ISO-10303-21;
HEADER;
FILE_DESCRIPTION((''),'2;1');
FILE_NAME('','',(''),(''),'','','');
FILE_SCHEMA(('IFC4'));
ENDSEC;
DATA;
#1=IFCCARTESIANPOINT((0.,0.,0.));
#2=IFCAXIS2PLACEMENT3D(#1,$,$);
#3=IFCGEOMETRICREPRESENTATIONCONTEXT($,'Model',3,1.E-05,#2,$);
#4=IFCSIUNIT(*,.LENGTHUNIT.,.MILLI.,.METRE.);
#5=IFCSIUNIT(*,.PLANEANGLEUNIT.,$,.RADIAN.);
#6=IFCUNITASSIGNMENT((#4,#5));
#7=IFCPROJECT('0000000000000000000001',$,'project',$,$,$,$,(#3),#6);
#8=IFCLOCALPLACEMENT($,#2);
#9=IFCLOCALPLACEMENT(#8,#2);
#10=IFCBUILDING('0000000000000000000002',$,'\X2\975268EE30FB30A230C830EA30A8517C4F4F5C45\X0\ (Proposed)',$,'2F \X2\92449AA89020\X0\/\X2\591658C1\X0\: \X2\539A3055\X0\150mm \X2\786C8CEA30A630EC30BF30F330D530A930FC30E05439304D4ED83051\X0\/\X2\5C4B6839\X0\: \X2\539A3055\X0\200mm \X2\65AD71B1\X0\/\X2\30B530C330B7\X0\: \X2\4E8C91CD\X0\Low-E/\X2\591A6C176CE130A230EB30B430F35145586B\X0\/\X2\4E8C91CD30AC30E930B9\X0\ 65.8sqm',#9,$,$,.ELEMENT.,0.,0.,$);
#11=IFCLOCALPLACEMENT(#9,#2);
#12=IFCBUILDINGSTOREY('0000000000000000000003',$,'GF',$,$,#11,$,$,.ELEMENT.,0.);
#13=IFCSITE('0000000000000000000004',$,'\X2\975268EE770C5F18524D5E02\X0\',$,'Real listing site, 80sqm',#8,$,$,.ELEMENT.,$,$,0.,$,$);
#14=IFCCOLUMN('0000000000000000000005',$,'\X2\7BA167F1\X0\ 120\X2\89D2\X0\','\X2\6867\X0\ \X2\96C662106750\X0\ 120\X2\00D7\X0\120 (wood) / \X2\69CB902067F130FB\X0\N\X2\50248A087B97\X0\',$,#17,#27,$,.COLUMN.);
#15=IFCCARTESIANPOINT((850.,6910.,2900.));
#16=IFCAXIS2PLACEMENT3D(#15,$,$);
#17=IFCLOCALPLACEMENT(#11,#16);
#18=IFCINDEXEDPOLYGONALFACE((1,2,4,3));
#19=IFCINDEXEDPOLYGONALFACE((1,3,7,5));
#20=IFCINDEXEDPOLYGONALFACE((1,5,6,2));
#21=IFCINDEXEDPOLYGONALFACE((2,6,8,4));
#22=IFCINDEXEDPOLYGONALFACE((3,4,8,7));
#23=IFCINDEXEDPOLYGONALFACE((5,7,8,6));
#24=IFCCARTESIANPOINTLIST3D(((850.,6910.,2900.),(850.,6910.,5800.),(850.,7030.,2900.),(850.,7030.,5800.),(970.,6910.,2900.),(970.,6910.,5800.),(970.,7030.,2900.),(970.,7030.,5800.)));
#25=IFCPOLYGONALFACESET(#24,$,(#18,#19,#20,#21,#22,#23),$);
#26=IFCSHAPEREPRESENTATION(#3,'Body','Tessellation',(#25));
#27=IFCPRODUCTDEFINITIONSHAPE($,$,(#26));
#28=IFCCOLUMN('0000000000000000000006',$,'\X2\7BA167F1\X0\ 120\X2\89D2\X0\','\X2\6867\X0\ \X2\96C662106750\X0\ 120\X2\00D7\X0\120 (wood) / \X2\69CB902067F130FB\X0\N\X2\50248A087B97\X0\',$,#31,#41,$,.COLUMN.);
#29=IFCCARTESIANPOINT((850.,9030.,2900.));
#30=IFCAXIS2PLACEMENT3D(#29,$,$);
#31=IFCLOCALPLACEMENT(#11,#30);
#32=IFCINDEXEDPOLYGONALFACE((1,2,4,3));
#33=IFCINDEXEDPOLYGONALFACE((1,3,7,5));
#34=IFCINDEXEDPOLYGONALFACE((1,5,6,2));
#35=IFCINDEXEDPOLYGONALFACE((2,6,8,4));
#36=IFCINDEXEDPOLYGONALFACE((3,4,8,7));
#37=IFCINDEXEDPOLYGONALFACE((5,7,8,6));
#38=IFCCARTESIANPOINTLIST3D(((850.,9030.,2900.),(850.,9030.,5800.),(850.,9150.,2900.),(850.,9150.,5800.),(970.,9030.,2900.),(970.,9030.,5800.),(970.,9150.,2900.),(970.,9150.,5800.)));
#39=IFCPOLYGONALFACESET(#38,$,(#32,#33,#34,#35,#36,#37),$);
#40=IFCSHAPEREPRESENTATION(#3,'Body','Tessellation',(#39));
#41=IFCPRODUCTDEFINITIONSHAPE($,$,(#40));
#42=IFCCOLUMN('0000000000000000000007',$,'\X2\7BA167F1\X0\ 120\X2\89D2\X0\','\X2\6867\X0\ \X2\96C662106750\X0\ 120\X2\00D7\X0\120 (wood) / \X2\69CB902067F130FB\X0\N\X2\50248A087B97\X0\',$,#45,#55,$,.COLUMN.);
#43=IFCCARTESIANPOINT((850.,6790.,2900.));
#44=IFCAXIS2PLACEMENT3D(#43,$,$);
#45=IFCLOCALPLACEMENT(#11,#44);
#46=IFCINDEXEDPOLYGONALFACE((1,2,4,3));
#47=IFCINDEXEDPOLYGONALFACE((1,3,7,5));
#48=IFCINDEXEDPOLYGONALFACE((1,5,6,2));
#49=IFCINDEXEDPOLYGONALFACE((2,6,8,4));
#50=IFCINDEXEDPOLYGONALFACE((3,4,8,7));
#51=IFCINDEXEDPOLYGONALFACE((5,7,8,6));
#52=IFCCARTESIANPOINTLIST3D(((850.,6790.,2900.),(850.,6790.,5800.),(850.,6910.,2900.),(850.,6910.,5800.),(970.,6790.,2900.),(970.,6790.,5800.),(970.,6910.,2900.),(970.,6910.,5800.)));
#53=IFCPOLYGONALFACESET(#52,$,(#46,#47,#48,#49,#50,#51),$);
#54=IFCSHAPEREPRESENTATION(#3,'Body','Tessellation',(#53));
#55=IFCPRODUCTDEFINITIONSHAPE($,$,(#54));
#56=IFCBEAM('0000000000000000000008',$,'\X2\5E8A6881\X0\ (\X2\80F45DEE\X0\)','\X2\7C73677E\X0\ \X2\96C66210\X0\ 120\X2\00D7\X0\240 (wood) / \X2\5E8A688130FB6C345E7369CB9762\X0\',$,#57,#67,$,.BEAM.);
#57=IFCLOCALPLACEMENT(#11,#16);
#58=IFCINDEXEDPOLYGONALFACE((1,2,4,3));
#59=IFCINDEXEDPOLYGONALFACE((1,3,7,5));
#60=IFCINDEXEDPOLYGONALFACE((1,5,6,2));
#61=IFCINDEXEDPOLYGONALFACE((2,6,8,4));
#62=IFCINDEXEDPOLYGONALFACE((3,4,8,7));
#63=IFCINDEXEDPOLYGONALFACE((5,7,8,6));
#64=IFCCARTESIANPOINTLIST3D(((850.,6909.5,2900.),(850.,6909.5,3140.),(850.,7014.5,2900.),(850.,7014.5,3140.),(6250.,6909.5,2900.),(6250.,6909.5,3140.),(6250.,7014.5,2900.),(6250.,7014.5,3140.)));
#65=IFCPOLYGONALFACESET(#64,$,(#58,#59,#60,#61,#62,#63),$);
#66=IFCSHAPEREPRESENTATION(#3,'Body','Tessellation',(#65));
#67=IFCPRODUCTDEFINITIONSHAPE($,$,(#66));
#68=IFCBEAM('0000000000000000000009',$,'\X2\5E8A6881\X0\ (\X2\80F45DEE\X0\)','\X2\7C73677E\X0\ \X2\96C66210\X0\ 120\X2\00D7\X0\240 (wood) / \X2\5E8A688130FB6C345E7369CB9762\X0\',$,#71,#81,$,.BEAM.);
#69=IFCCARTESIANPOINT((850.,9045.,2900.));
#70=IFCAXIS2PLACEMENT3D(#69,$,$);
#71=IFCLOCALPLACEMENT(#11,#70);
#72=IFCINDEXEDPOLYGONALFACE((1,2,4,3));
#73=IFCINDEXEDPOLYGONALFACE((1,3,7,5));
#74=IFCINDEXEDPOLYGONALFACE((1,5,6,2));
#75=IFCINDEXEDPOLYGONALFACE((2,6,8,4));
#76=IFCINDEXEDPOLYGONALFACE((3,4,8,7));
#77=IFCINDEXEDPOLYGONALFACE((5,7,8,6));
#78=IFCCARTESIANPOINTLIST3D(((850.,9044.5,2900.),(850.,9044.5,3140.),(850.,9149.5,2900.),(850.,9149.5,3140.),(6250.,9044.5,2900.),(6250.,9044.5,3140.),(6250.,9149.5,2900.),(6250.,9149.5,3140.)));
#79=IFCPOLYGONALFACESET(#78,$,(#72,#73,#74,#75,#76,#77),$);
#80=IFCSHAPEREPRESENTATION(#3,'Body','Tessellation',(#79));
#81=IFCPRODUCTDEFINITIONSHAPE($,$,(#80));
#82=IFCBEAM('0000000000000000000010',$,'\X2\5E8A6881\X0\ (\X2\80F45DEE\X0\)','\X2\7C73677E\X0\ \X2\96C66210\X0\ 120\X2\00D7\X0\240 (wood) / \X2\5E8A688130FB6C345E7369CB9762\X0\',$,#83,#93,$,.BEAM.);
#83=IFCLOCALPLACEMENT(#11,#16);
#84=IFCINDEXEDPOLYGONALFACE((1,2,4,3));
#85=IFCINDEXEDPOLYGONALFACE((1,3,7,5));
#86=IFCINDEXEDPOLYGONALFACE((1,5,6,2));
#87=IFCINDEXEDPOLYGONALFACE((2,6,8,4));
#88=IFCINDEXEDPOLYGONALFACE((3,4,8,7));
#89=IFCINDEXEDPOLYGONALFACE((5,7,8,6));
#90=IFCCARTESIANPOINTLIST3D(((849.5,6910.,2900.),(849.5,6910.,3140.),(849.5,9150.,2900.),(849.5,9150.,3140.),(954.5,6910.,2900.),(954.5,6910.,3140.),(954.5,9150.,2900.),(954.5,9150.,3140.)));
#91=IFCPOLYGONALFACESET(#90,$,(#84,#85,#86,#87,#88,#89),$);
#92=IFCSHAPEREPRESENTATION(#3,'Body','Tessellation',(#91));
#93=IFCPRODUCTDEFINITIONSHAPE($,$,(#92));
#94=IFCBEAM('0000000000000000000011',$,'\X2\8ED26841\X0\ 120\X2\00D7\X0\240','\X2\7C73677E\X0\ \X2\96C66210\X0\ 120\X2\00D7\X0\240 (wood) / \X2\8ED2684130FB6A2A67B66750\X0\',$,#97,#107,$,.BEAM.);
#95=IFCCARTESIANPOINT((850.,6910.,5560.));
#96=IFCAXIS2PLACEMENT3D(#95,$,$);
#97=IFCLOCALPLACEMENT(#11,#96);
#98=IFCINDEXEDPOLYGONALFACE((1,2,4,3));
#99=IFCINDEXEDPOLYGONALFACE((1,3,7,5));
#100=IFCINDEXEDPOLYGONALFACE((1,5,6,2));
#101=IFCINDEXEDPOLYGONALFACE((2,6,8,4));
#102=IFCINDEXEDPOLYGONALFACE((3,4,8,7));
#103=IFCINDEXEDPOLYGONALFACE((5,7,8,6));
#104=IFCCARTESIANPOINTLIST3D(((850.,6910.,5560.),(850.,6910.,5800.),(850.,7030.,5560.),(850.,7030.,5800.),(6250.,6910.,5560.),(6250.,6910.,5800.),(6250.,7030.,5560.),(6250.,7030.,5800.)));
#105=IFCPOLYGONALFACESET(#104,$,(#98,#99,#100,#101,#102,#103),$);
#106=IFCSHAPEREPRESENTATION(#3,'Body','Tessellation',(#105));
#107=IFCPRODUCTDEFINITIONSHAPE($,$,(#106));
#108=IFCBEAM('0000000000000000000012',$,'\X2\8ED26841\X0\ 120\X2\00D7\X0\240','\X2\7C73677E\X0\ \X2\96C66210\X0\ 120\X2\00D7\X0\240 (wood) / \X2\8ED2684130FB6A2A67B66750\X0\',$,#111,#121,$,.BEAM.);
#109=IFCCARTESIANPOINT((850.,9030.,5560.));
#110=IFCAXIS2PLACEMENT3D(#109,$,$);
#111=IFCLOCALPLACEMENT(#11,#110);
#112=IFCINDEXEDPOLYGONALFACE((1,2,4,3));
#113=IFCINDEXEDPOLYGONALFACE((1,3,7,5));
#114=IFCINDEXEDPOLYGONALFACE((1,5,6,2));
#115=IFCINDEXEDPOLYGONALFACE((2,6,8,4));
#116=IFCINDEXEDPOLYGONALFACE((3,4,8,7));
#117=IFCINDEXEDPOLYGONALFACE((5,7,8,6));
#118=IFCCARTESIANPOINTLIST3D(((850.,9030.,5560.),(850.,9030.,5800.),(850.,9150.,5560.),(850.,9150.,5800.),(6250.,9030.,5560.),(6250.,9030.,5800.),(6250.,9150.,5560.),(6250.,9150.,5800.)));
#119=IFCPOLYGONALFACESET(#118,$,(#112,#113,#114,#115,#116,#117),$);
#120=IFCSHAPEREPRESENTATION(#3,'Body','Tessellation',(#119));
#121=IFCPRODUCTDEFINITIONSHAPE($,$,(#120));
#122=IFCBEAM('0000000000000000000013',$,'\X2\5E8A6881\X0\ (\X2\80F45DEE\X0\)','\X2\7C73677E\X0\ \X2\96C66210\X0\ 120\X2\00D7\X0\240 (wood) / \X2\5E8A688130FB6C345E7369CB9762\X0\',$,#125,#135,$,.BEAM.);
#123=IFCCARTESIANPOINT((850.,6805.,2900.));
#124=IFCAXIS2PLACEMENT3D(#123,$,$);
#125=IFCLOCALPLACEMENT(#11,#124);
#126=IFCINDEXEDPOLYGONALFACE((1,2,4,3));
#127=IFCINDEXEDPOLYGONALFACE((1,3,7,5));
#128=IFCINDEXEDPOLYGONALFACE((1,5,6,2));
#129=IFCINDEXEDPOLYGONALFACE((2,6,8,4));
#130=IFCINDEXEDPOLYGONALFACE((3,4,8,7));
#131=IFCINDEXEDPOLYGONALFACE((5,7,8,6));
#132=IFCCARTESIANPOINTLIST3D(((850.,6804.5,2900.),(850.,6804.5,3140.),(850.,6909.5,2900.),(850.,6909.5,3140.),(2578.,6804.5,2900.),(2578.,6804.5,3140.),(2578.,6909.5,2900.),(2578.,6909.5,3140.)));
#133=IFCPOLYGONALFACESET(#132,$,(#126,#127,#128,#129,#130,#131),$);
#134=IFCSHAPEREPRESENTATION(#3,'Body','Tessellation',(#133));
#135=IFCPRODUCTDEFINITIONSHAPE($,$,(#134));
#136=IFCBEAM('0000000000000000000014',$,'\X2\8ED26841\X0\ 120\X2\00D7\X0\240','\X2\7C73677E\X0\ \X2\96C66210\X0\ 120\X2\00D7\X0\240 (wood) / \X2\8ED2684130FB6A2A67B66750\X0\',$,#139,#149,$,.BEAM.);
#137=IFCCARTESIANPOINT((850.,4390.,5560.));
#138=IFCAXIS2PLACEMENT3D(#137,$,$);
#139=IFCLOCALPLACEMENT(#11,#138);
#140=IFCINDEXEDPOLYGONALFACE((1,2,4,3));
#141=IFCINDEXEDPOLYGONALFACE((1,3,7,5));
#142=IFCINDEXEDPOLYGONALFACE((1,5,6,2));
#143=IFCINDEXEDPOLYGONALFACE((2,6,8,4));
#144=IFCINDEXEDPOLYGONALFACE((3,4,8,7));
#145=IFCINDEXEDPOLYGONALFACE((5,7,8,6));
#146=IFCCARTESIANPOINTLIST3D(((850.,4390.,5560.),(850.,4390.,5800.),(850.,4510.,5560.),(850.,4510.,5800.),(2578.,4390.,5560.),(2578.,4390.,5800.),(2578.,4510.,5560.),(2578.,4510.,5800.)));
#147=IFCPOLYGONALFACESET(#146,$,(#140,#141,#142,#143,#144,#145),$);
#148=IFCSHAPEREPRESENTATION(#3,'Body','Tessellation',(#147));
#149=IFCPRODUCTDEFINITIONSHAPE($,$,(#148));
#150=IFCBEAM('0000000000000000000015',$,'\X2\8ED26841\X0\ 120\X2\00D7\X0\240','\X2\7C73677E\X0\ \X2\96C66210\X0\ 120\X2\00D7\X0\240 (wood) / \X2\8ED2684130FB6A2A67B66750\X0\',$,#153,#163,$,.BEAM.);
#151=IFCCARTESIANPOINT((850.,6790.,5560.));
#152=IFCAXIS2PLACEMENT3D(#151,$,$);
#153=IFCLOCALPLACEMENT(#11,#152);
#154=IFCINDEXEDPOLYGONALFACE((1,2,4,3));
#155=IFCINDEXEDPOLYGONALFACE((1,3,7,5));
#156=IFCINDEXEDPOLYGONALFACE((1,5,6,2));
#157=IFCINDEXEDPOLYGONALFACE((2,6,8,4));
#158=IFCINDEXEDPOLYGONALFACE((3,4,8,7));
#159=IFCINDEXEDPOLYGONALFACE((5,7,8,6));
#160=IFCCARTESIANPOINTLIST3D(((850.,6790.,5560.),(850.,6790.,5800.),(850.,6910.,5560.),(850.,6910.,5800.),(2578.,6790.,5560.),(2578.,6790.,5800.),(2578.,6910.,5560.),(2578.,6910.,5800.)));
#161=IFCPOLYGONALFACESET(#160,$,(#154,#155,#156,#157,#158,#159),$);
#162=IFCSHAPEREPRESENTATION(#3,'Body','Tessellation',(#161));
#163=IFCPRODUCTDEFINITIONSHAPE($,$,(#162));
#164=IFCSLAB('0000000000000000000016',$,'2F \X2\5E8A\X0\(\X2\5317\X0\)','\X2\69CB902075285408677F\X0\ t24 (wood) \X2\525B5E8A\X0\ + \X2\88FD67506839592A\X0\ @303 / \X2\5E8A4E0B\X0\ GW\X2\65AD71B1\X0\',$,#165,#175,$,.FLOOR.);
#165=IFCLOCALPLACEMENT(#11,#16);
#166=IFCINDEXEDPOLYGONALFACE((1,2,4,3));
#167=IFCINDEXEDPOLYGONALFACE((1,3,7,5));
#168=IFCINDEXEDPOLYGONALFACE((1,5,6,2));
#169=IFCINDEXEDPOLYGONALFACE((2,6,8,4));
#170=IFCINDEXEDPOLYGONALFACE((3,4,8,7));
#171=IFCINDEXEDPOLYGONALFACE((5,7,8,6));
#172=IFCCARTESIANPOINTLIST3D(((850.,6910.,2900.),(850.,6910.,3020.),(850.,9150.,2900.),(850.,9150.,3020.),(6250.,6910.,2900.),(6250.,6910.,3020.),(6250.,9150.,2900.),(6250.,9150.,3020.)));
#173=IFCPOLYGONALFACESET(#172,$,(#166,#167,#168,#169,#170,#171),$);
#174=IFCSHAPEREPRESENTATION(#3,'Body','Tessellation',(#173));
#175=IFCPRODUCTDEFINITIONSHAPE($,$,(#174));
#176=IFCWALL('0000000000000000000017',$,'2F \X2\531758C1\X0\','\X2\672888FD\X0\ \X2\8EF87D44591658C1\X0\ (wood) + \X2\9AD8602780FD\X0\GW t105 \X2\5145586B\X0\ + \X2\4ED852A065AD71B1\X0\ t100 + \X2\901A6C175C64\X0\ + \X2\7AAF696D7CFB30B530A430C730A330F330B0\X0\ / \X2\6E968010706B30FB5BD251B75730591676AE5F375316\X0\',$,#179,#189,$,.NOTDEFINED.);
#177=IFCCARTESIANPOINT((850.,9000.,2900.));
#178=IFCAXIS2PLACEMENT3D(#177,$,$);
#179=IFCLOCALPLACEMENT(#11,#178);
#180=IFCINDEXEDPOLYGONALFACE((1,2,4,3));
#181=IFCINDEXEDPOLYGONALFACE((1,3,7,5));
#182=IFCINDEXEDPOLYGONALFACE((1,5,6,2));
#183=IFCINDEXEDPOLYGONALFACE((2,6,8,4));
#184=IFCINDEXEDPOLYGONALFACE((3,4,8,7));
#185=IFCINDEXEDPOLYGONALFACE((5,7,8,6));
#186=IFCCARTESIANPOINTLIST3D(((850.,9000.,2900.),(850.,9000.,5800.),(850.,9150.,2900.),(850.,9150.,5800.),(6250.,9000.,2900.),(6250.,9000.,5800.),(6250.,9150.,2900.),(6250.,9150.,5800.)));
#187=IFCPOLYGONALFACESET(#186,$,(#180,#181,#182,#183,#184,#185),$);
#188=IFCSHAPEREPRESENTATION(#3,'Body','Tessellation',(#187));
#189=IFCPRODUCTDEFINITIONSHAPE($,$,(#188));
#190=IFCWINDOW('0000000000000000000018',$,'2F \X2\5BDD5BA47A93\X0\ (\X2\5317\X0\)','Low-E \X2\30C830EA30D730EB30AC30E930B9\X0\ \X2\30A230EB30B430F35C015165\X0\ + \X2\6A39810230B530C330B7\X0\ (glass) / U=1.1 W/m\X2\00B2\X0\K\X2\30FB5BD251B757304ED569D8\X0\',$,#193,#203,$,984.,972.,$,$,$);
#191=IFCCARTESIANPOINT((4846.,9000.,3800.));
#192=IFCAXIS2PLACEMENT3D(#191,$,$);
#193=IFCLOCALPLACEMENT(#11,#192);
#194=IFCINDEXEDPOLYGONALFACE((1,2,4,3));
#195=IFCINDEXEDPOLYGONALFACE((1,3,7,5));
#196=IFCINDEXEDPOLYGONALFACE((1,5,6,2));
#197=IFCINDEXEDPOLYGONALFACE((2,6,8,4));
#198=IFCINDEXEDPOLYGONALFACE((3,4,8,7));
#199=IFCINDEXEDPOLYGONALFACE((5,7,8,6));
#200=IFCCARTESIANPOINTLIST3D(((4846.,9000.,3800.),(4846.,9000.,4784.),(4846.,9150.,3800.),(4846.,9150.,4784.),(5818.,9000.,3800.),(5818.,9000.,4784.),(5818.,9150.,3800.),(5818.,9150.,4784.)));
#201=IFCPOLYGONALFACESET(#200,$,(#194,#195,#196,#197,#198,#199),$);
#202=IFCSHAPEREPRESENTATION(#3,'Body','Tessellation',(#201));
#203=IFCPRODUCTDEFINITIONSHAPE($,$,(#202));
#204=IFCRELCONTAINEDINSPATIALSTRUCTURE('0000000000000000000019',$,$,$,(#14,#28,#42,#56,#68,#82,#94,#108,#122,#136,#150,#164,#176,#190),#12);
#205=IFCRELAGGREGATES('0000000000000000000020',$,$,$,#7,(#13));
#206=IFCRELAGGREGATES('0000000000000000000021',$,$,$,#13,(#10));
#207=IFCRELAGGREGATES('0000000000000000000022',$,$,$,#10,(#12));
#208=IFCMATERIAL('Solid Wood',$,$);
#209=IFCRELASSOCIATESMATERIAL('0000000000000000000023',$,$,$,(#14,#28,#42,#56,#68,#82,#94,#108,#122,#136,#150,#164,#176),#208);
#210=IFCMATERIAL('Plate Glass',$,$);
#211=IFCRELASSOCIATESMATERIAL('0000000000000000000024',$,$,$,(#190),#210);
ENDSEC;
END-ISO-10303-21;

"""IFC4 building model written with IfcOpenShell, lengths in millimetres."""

from ifc_helpers import new_model, si_unit, frame, frame_2d, origin, place, context, project, spatial, rectangle, extrude, material, element, fill, save


model = new_model("IFC4")

# Units and contexts
model_context = context("Model", 3, precision=1e-05, world=origin())
ifc_project = project(units=[si_unit("LENGTHUNIT", "METRE", prefix="MILLI"), si_unit("PLANEANGLEUNIT", "RADIAN")], contexts=[model_context])

# Site, building, storey
site_placement = place(None, origin())
site = spatial("IfcSite", under=ifc_project, at=site_placement, Name="青森県弘前市", ObjectType="Real listing site, 80sqm", CompositionType="ELEMENT", RefElevation=0.0)
building_placement = place(site_placement, origin())
building = spatial("IfcBuilding", under=site, at=building_placement, Name="青森・アトリエ兼住居 (Proposed)", ObjectType="2F 鉄骨造/外壁: 厚さ150mm 硬質ウレタンフォーム吹き付け/屋根: 厚さ200mm 断熱/サッシ: 二重Low-E/多気泡アルゴン充填/二重ガラス 65.8sqm", CompositionType="ELEMENT", ElevationOfRefHeight=0.0, ElevationOfTerrain=0.0)
storey_placement = place(building_placement, origin())
storey = spatial("IfcBuildingStorey", under=building, at=storey_placement, Name="GF", CompositionType="ELEMENT", Elevation=0.0)

# Columns
ifc_material_1 = material(Name="Solid Wood")
column_1_placement = place(storey_placement, frame((850.0, 6910.0, 2900.0)))
element("IfcColumn", 1, at=column_1_placement, inside=storey, material=ifc_material_1, Name="管柱 120角", Description="桧 集成材 120×120 (wood) / 構造柱・N値計算", PredefinedType="COLUMN", context=model_context, shape_type="SweptSolid", body=[
    extrude(rectangle(XDim=120.0, YDim=120.0, at=frame_2d((60.0, 60.0))), frame((850.0, 6910.0, 2900.0)), (0.0, 0.0, 1.0), 2900.0),
])
column_2_placement = place(storey_placement, frame((850.0, 9030.0, 2900.0)))
element("IfcColumn", 2, at=column_2_placement, inside=storey, material=ifc_material_1, Name="管柱 120角", Description="桧 集成材 120×120 (wood) / 構造柱・N値計算", PredefinedType="COLUMN", context=model_context, shape_type="SweptSolid", body=[
    extrude(rectangle(XDim=120.0, YDim=120.0, at=frame_2d((60.0, 60.0))), frame((850.0, 9030.0, 2900.0)), (0.0, 0.0, 1.0), 2900.0),
])
column_3_placement = place(storey_placement, frame((850.0, 6790.0, 2900.0)))
element("IfcColumn", 3, at=column_3_placement, inside=storey, material=ifc_material_1, Name="管柱 120角", Description="桧 集成材 120×120 (wood) / 構造柱・N値計算", PredefinedType="COLUMN", context=model_context, shape_type="SweptSolid", body=[
    extrude(rectangle(XDim=120.0, YDim=120.0, at=frame_2d((60.0, 60.0))), frame((850.0, 6790.0, 2900.0)), (0.0, 0.0, 1.0), 2900.0),
])

# Beams
beam_1_placement = place(storey_placement, frame((850.0, 6910.0, 2900.0)))
element("IfcBeam", 4, at=beam_1_placement, inside=storey, material=ifc_material_1, Name="床梁 (胴差)", Description="米松 集成 120×240 (wood) / 床梁・水平構面", PredefinedType="BEAM", context=model_context, shape_type="SweptSolid", body=[
    extrude(rectangle(XDim=5400.0, YDim=105.0, at=frame_2d((2700.0, 52.0))), frame((850.0, 6910.0, 2900.0)), (0.0, 0.0, 1.0), 240.0),
])
beam_2_placement = place(storey_placement, frame((850.0, 9045.0, 2900.0)))
element("IfcBeam", 5, at=beam_2_placement, inside=storey, material=ifc_material_1, Name="床梁 (胴差)", Description="米松 集成 120×240 (wood) / 床梁・水平構面", PredefinedType="BEAM", context=model_context, shape_type="SweptSolid", body=[
    extrude(rectangle(XDim=5400.0, YDim=105.0, at=frame_2d((2700.0, 52.0))), frame((850.0, 9045.0, 2900.0)), (0.0, 0.0, 1.0), 240.0),
])
beam_3_placement = place(storey_placement, frame((850.0, 6910.0, 2900.0)))
element("IfcBeam", 6, at=beam_3_placement, inside=storey, material=ifc_material_1, Name="床梁 (胴差)", Description="米松 集成 120×240 (wood) / 床梁・水平構面", PredefinedType="BEAM", context=model_context, shape_type="SweptSolid", body=[
    extrude(rectangle(XDim=105.0, YDim=2240.0, at=frame_2d((52.0, 1120.0))), frame((850.0, 6910.0, 2900.0)), (0.0, 0.0, 1.0), 240.0),
])
beam_4_placement = place(storey_placement, frame((850.0, 6910.0, 5560.0)))
element("IfcBeam", 7, at=beam_4_placement, inside=storey, material=ifc_material_1, Name="軒桁 120×240", Description="米松 集成 120×240 (wood) / 軒桁・横架材", PredefinedType="BEAM", context=model_context, shape_type="SweptSolid", body=[
    extrude(rectangle(XDim=5400.0, YDim=120.0, at=frame_2d((2700.0, 60.0))), frame((850.0, 6910.0, 5560.0)), (0.0, 0.0, 1.0), 240.0),
])
beam_5_placement = place(storey_placement, frame((850.0, 9030.0, 5560.0)))
element("IfcBeam", 8, at=beam_5_placement, inside=storey, material=ifc_material_1, Name="軒桁 120×240", Description="米松 集成 120×240 (wood) / 軒桁・横架材", PredefinedType="BEAM", context=model_context, shape_type="SweptSolid", body=[
    extrude(rectangle(XDim=5400.0, YDim=120.0, at=frame_2d((2700.0, 60.0))), frame((850.0, 9030.0, 5560.0)), (0.0, 0.0, 1.0), 240.0),
])
beam_6_placement = place(storey_placement, frame((850.0, 6805.0, 2900.0)))
element("IfcBeam", 9, at=beam_6_placement, inside=storey, material=ifc_material_1, Name="床梁 (胴差)", Description="米松 集成 120×240 (wood) / 床梁・水平構面", PredefinedType="BEAM", context=model_context, shape_type="SweptSolid", body=[
    extrude(rectangle(XDim=1728.0, YDim=105.0, at=frame_2d((864.0, 52.0))), frame((850.0, 6805.0, 2900.0)), (0.0, 0.0, 1.0), 240.0),
])
beam_7_placement = place(storey_placement, frame((850.0, 4390.0, 5560.0)))
element("IfcBeam", 10, at=beam_7_placement, inside=storey, material=ifc_material_1, Name="軒桁 120×240", Description="米松 集成 120×240 (wood) / 軒桁・横架材", PredefinedType="BEAM", context=model_context, shape_type="SweptSolid", body=[
    extrude(rectangle(XDim=1728.0, YDim=120.0, at=frame_2d((864.0, 60.0))), frame((850.0, 4390.0, 5560.0)), (0.0, 0.0, 1.0), 240.0),
])
beam_8_placement = place(storey_placement, frame((850.0, 6790.0, 5560.0)))
element("IfcBeam", 11, at=beam_8_placement, inside=storey, material=ifc_material_1, Name="軒桁 120×240", Description="米松 集成 120×240 (wood) / 軒桁・横架材", PredefinedType="BEAM", context=model_context, shape_type="SweptSolid", body=[
    extrude(rectangle(XDim=1728.0, YDim=120.0, at=frame_2d((864.0, 60.0))), frame((850.0, 6790.0, 5560.0)), (0.0, 0.0, 1.0), 240.0),
])

# Slab
slab_placement = place(storey_placement, frame((850.0, 6910.0, 2900.0)))
element("IfcSlab", 12, at=slab_placement, inside=storey, material=ifc_material_1, Name="2F 床(北)", Description="構造用合板 t24 (wood) 剛床 + 製材根太 @303 / 床下 GW断熱", PredefinedType="FLOOR", context=model_context, shape_type="SweptSolid", body=[
    extrude(rectangle(XDim=5400.0, YDim=2240.0, at=frame_2d((2700.0, 1120.0))), frame((850.0, 6910.0, 2900.0)), (0.0, 0.0, 1.0), 120.0),
])

# Wall, opening, window
wall_placement = place(storey_placement, frame((850.0, 9000.0, 2900.0)))
wall = element("IfcWall", 13, at=wall_placement, inside=storey, material=ifc_material_1, Name="2F 北壁", Description="木製 軸組外壁 (wood) + 高性能GW t105 充填 + 付加断熱 t100 + 通気層 + 窯業系サイディング / 準耐火・寒冷地外皮強化", PredefinedType="NOTDEFINED", context=model_context, shape_type="SweptSolid", body=[
    extrude(rectangle(XDim=5400.0, YDim=150.0, at=frame_2d((2700.0, 75.0))), frame((850.0, 9000.0, 2900.0)), (0.0, 0.0, 1.0), 2900.0),
])
opening_placement = place(storey_placement, frame((4846.0, 9000.0, 3800.0)))
opening = element("IfcOpeningElement", 14, at=opening_placement, cuts=wall, PredefinedType="NOTDEFINED", context=model_context, shape_type="SweptSolid", body=[
    extrude(rectangle(XDim=972.0, YDim=150.0, at=frame_2d((486.0, 75.0))), frame((4846.0, 9000.0, 3800.0)), (0.0, 0.0, 1.0), 984.0),
])
ifc_material_2 = material(Name="Plate Glass")
window_placement = place(storey_placement, frame((4846.0, 9000.0, 3800.0)))
window = element("IfcWindow", 15, at=window_placement, inside=storey, material=ifc_material_2, Name="2F 寝室窓 (北)", Description="Low-E トリプルガラス アルゴン封入 + 樹脂サッシ (glass) / U=1.1 W/m²K・寒冷地仕様", OverallHeight=984.0, OverallWidth=972.0, context=model_context, shape_type="SweptSolid", body=[
    extrude(rectangle(XDim=972.0, YDim=150.0, at=frame_2d((486.0, 75.0))), frame((4846.0, 9000.0, 3800.0)), (0.0, 0.0, 1.0), 984.0),
])
fill(opening, window)

save(model, "model.ifc")
